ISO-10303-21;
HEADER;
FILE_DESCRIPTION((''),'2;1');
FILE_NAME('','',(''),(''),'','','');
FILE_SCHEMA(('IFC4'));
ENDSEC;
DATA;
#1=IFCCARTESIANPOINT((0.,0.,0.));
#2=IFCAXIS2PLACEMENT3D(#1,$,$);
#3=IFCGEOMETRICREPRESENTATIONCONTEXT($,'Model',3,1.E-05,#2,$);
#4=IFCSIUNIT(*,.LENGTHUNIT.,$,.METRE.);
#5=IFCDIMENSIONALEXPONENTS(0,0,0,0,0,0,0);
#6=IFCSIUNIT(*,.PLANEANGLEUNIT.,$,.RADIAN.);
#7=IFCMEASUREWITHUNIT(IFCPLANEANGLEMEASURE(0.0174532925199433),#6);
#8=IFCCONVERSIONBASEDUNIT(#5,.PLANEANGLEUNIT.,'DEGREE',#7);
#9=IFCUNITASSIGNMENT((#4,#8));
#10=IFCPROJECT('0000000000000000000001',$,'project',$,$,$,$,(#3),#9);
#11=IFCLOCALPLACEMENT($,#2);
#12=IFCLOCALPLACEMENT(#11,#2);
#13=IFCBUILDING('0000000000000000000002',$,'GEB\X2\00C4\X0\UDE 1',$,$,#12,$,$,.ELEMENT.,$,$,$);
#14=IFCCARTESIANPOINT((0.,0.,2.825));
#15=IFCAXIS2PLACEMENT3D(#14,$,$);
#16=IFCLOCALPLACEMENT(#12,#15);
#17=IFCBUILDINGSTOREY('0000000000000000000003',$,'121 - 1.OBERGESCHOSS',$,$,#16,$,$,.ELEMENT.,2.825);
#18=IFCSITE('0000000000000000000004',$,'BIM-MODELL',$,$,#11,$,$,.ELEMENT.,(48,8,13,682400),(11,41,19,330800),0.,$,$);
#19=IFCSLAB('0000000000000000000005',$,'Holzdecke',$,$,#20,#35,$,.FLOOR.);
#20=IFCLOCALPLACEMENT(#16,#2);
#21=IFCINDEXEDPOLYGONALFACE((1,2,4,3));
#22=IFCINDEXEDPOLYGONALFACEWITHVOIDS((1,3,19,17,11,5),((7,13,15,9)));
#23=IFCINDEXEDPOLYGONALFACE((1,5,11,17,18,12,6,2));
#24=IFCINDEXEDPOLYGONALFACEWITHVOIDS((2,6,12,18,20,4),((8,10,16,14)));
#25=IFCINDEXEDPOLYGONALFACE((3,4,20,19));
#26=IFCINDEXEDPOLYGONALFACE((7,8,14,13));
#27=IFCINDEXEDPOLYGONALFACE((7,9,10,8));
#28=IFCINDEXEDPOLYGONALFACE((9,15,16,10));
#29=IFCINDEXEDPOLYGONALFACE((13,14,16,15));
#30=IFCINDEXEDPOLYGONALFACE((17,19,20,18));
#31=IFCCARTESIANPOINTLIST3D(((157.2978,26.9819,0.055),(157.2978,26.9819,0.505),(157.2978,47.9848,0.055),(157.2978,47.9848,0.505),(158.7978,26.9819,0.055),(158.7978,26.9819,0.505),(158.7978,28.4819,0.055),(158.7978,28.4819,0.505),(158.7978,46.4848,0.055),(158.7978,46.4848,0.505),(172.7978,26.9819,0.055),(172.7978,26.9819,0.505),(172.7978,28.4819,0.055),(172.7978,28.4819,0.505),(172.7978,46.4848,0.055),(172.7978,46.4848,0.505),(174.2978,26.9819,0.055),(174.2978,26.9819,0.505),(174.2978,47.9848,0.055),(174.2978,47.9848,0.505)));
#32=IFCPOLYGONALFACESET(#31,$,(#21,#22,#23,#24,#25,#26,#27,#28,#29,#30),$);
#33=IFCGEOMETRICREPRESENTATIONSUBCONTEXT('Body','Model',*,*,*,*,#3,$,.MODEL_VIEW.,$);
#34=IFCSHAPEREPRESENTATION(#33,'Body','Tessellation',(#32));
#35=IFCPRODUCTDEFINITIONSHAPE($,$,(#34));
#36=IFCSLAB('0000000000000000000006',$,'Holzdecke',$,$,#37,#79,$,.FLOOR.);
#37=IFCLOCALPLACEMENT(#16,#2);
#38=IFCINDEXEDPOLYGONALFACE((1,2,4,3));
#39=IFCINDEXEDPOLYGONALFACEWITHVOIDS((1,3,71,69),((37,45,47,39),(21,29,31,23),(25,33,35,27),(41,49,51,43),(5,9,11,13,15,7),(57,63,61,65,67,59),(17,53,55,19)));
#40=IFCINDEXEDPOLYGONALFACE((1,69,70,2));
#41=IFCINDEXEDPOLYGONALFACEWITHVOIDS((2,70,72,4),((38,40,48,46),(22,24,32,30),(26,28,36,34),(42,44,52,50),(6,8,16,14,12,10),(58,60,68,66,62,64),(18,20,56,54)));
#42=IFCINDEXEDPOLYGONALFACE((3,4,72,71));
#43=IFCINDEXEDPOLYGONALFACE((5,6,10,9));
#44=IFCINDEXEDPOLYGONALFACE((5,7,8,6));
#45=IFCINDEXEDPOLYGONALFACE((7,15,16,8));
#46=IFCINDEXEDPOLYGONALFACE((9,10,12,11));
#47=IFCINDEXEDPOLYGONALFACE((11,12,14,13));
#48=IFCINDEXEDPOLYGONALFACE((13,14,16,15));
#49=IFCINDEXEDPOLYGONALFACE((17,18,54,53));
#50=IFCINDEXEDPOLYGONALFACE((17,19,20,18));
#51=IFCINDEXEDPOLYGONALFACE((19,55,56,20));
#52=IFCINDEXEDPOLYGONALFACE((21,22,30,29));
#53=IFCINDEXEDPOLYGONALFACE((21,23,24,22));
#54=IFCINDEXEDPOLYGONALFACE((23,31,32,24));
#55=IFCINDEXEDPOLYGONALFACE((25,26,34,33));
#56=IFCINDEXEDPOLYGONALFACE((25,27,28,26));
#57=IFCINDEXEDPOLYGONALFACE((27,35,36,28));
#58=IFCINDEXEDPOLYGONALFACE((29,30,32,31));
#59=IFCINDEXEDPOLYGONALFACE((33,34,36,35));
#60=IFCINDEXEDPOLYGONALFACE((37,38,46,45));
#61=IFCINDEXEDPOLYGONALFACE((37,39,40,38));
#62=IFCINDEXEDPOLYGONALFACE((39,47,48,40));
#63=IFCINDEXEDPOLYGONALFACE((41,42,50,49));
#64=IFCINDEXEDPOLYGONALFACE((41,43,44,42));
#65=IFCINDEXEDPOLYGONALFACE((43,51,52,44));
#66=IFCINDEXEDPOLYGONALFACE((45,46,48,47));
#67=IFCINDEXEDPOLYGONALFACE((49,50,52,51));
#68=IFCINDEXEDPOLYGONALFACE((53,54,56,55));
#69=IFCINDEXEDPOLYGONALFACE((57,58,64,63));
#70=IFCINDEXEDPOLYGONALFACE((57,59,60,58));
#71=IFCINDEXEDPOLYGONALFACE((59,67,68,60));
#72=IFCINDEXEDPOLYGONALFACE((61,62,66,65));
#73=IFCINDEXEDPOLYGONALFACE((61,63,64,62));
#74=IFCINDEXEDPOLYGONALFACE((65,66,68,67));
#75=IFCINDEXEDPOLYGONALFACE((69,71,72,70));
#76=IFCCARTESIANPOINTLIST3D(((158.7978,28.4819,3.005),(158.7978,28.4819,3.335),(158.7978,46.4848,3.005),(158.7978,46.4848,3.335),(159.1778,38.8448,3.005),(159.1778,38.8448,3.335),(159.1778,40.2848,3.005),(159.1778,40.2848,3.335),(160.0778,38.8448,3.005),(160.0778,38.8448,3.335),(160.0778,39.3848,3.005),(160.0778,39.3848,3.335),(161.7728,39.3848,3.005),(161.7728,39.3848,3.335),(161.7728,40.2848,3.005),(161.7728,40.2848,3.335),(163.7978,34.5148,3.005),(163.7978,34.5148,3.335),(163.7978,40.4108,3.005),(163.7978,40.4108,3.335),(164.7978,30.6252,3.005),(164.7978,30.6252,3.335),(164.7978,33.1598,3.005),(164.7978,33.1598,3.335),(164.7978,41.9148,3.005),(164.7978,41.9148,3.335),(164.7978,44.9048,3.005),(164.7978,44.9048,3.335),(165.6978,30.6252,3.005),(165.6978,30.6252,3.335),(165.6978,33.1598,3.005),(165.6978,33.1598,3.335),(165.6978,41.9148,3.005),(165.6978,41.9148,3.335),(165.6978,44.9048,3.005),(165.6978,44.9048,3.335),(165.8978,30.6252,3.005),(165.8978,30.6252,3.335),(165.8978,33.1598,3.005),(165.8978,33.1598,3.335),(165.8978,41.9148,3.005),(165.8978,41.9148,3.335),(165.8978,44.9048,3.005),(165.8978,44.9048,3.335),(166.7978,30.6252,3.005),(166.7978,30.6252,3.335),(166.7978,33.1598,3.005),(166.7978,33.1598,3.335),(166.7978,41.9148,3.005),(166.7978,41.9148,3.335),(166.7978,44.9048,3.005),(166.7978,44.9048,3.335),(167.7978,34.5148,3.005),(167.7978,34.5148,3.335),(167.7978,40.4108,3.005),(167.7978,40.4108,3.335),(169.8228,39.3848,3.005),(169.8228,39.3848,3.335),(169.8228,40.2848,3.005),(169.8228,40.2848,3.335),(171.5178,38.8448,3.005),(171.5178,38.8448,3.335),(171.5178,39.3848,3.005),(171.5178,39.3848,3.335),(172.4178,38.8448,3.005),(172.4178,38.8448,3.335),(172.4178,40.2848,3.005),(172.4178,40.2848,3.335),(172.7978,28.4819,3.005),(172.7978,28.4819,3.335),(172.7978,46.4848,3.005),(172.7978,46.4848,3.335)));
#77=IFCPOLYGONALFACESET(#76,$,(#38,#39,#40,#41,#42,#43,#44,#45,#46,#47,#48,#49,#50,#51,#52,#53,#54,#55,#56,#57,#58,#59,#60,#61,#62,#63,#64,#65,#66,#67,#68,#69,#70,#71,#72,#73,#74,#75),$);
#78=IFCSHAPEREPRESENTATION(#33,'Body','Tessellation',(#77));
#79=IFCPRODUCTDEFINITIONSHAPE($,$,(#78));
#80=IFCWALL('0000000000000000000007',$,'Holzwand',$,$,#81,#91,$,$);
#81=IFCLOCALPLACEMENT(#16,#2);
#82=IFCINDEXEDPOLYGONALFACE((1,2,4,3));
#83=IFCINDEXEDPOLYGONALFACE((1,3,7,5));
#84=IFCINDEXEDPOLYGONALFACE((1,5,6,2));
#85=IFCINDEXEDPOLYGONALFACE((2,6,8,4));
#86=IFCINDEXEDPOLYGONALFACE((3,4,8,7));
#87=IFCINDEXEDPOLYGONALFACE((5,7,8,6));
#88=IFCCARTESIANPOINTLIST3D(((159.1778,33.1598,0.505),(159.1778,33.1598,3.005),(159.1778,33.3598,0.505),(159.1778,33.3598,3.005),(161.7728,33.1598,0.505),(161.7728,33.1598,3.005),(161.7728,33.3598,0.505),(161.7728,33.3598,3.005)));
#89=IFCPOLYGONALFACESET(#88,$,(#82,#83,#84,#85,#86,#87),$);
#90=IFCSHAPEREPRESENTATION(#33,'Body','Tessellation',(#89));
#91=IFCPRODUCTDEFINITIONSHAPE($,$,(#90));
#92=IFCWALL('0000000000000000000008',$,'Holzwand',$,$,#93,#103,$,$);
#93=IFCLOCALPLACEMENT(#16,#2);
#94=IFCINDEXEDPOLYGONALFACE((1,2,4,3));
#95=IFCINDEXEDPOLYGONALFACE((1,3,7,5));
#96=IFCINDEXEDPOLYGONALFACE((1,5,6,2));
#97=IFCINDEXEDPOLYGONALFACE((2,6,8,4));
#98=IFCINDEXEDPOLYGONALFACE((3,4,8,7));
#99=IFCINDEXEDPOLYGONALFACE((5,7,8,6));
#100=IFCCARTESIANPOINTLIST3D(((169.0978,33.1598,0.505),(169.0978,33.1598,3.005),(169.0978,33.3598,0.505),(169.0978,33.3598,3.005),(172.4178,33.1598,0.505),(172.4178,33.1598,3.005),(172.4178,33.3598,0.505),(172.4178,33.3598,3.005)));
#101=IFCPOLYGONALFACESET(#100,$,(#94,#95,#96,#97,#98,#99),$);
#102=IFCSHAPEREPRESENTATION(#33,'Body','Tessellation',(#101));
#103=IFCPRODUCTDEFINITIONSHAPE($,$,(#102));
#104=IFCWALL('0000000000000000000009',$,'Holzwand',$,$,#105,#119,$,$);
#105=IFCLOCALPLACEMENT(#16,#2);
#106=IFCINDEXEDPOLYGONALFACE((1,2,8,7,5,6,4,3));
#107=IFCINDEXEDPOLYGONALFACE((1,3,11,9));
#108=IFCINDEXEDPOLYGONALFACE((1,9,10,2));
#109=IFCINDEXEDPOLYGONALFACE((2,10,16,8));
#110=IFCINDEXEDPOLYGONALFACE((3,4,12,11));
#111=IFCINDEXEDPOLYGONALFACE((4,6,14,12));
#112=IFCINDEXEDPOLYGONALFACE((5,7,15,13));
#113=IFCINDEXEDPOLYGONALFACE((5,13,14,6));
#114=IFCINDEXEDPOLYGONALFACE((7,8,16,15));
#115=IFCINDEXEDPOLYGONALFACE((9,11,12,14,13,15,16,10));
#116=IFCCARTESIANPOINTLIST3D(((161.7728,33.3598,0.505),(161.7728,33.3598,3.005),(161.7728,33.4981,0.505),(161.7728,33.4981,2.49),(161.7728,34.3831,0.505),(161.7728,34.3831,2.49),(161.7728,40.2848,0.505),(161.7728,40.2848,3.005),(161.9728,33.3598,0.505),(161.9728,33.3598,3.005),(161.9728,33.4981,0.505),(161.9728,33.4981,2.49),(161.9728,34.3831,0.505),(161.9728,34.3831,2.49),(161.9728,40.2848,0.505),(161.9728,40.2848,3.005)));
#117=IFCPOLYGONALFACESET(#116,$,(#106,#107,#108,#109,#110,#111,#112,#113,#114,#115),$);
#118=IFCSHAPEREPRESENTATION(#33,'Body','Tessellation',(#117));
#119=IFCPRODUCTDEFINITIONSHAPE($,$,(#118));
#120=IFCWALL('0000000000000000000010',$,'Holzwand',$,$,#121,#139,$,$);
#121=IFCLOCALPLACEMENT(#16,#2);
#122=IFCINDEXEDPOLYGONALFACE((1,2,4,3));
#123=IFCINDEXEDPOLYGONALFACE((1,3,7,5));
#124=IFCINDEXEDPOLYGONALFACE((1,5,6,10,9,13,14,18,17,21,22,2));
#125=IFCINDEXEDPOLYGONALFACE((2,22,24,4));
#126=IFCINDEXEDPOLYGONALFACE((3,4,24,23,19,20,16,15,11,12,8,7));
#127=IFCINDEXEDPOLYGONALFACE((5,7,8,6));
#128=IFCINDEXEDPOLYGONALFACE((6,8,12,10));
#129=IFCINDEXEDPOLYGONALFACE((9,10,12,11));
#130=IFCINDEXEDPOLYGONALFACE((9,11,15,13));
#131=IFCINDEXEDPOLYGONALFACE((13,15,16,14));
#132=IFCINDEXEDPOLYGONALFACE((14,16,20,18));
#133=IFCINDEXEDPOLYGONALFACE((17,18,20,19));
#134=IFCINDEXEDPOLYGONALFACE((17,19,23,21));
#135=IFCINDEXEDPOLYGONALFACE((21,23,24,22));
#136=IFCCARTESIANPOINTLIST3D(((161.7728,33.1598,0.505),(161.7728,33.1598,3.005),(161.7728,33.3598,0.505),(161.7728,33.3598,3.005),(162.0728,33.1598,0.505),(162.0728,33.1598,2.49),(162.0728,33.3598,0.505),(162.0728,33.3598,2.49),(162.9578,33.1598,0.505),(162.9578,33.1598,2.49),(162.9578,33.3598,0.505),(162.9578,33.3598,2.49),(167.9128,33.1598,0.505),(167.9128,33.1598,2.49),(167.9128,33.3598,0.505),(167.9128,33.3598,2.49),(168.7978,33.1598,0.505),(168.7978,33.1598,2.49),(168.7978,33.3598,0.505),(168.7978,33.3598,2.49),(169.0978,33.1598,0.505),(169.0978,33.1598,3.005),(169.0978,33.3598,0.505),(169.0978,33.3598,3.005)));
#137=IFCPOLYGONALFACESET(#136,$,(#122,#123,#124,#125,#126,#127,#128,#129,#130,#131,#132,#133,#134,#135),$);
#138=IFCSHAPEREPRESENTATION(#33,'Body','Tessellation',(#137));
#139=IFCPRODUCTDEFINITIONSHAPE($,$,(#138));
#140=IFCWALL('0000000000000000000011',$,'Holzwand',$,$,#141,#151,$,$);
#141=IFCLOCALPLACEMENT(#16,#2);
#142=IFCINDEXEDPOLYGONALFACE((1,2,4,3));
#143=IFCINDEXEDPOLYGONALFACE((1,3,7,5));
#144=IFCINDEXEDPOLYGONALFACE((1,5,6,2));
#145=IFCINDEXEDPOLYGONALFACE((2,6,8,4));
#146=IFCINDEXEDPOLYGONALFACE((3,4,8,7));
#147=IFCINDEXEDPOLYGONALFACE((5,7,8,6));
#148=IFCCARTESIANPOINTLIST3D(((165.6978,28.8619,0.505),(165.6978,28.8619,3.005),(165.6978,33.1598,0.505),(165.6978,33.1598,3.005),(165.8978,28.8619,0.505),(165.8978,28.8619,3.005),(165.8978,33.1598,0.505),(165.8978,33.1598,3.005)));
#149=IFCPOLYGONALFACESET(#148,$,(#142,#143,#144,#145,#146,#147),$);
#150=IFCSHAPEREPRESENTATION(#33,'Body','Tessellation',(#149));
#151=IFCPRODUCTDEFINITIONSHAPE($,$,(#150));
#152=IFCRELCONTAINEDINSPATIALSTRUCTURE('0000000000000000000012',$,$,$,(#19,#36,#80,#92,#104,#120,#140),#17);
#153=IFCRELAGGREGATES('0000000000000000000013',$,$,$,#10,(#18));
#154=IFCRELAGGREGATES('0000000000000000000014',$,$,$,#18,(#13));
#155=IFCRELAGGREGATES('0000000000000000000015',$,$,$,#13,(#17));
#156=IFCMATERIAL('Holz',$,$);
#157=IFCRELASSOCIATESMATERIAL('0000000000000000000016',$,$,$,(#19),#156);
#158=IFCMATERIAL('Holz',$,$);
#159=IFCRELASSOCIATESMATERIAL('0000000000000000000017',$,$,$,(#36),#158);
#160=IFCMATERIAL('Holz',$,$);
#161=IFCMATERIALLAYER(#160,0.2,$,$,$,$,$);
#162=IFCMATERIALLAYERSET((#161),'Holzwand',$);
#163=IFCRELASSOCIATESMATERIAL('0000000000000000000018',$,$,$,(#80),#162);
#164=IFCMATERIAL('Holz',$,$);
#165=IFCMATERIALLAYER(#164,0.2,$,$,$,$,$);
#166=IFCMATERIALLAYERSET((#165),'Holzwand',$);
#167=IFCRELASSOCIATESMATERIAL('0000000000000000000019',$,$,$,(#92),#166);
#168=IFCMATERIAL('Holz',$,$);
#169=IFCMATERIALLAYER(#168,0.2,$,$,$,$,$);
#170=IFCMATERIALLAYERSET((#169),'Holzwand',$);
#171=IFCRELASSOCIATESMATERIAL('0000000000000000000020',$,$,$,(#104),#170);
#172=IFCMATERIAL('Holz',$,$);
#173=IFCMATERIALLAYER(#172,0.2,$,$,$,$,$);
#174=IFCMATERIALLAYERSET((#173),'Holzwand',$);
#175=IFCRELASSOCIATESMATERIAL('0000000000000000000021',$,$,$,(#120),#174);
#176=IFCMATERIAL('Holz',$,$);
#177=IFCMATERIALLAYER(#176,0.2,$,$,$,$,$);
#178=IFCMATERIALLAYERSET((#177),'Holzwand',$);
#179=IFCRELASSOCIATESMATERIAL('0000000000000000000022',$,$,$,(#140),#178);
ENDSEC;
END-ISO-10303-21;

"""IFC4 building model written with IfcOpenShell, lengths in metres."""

from ifc_helpers import new_model, entity, si_unit, converted_unit, frame, frame_2d, origin, origin_with_axes, place, context, subcontext, project, spatial, polyline, rectangle, outline, extrude, material, layer, layer_set, layer_usage, element, save


model = new_model("IFC4")

# Units and contexts
model_context = context("Model", 3, precision=1e-05, world=origin())
body_context = subcontext(model_context, "Body", "Model", "MODEL_VIEW")
ifc_project = project(units=[si_unit("LENGTHUNIT", "METRE"), converted_unit("PLANEANGLEUNIT", "DEGREE", entity("IfcPlaneAngleMeasure", 0.0174532925199433), si_unit("PLANEANGLEUNIT", "RADIAN"), dimensions=[0, 0, 0, 0, 0, 0, 0])], contexts=[model_context])

# Site, building, storey
site_placement = place(None, origin())
site = spatial("IfcSite", under=ifc_project, at=site_placement, Name="BIM-MODELL", CompositionType="ELEMENT", RefLatitude=(48, 8, 13, 682400), RefLongitude=(11, 41, 19, 330800), RefElevation=0.0)
building_placement = place(site_placement, origin())
building = spatial("IfcBuilding", under=site, at=building_placement, Name="GEBÄUDE 1", CompositionType="ELEMENT")
storey_placement = place(building_placement, frame((0.0, 0.0, 2.825)))
storey = spatial("IfcBuildingStorey", under=building, at=storey_placement, Name="121 - 1.OBERGESCHOSS", CompositionType="ELEMENT", Elevation=2.825)

# Slab
ifc_material_1 = material(Name="Holz")
slab_1_placement = place(storey_placement, frame((157.2978, 26.9819, 0.055)))
element("IfcSlab", 1, at=slab_1_placement, inside=storey, material=ifc_material_1, Name="Holzdecke", PredefinedType="FLOOR", context=body_context, shape_type="SweptSolid", body=[
    extrude(outline(polyline([(17.0, 0.0), (17.0, 21.0029), (0.0, 21.0029), (0.0, 0.0), (1.5, 0.0), (15.5, 0.0), (17.0, 0.0)]), holes=[polyline([(15.5, 19.5029), (15.5, 1.5), (1.5, 1.5), (1.5, 19.5029), (15.5, 19.5029)])]), origin_with_axes(), (0.0, 0.0, 1.0), 0.45),
])

# Slab, opening
ifc_material_2 = material(Name="Holz")
slab_2_placement = place(storey_placement, frame((158.7978, 28.4819, 3.005)))
slab_2 = element("IfcSlab", 2, at=slab_2_placement, inside=storey, material=ifc_material_2, Name="Holzdecke", PredefinedType="FLOOR", context=body_context, shape_type="SweptSolid", body=[
    extrude(outline(polyline([(0.0, 0.0), (14.0, 0.0), (14.0, 18.0029), (0.0, 18.0029), (0.0, 0.0)]), holes=[polyline([(9.0, 6.0329), (5.0, 6.0329), (5.0, 11.9289), (9.0, 11.9289), (9.0, 6.0329)]), polyline([(13.62, 10.3629), (12.72, 10.3629), (12.72, 10.9029), (11.025, 10.9029), (11.025, 11.8029), (13.62, 11.8029), (13.62, 10.3629)]), polyline([(8.0, 16.4229), (8.0, 13.4329), (7.1, 13.4329), (7.1, 16.4229), (8.0, 16.4229)]), polyline([(6.0, 16.4229), (6.9, 16.4229), (6.9, 13.4329), (6.0, 13.4329), (6.0, 16.4229)]), polyline([(6.9, 2.1433), (6.0, 2.1433), (6.0, 4.6779), (6.9, 4.6779), (6.9, 2.1433)]), polyline([(8.0, 2.1433), (7.1, 2.1433), (7.1, 4.6779), (8.0, 4.6779), (8.0, 2.1433)])]), origin_with_axes(), (0.0, 0.0, 1.0), 0.33),
])
opening_1_placement = place(slab_2_placement, frame((0.38, 10.3629, 0.0)))
element("IfcOpeningElement", 3, at=opening_1_placement, cuts=slab_2, ObjectType="Opening", context=body_context, shape_type="SweptSolid", body=[
    extrude(outline(polyline([(1.43, 0.78), (-1.165, 0.78), (-1.165, -0.66), (-0.265, -0.66), (-0.265, -0.12), (1.43, -0.12), (1.43, 0.78)])), frame((1.165, 0.66, 0.0), z_axis=(0.0, 0.0, 1.0), x_axis=(1.0, 0.0, 0.0)), (0.0, 0.0, 1.0), 0.33),
])

# Walls
ifc_material_3 = material(Name="Holz")
ifc_layer_1 = layer(ifc_material_3, 0.2)
ifc_layer_set_1 = layer_set([ifc_layer_1], Name="Holzwand")
ifc_layer_usage_1 = layer_usage(ifc_layer_set_1, "AXIS2", "POSITIVE", 0.0)
wall_1_placement = place(storey_placement, frame((159.1778, 33.1598, 0.505)))
element("IfcWall", 4, at=wall_1_placement, inside=storey, material=ifc_layer_usage_1, Name="Holzwand", context=body_context, shape_type="SweptSolid", body=[
    extrude(rectangle(XDim=2.595, YDim=0.2, at=frame_2d((1.2975, 0.1), x_axis=(1.0, 0.0))), origin_with_axes(), (0.0, 0.0, 1.0), 2.5),
])
ifc_material_4 = material(Name="Holz")
ifc_layer_2 = layer(ifc_material_4, 0.2)
ifc_layer_set_2 = layer_set([ifc_layer_2], Name="Holzwand")
ifc_layer_usage_2 = layer_usage(ifc_layer_set_2, "AXIS2", "POSITIVE", 0.0)
wall_2_placement = place(storey_placement, frame((169.0978, 33.1598, 0.505)))
element("IfcWall", 5, at=wall_2_placement, inside=storey, material=ifc_layer_usage_2, Name="Holzwand", context=body_context, shape_type="SweptSolid", body=[
    extrude(rectangle(XDim=3.32, YDim=0.2, at=frame_2d((1.66, 0.1), x_axis=(1.0, 0.0))), origin_with_axes(), (0.0, 0.0, 1.0), 2.5),
])

# Wall, opening
ifc_material_5 = material(Name="Holz")
ifc_layer_3 = layer(ifc_material_5, 0.2)
ifc_layer_set_3 = layer_set([ifc_layer_3], Name="Holzwand")
ifc_layer_usage_3 = layer_usage(ifc_layer_set_3, "AXIS2", "POSITIVE", 0.0)
wall_3_placement = place(storey_placement, frame((161.9728, 33.3598, 0.505), z_axis=(0.0, 0.0, 1.0), x_axis=(0.0, 1.0, 0.0)))
wall_3 = element("IfcWall", 6, at=wall_3_placement, inside=storey, material=ifc_layer_usage_3, Name="Holzwand", context=body_context, shape_type="SweptSolid", body=[
    extrude(rectangle(XDim=6.925, YDim=0.2, at=frame_2d((3.4625, 0.1), x_axis=(1.0, 0.0))), origin_with_axes(), (0.0, 0.0, 1.0), 2.5),
])
opening_2_placement = place(wall_3_placement, frame((0.1383, 0.0, -0.15), z_axis=(0.0, 1.0, 0.0), x_axis=(0.0, 0.0, 1.0)))
element("IfcOpeningElement", 7, at=opening_2_placement, cuts=wall_3, ObjectType="Opening", context=body_context, shape_type="SweptSolid", body=[
    extrude(outline(polyline([(0.0, 0.885), (2.135, 0.885), (2.135, 0.0), (0.0, 0.0), (0.0, 0.885)])), origin_with_axes(), (0.0, 0.0, 1.0), 0.2),
])

# Wall, openings
ifc_material_6 = material(Name="Holz")
ifc_layer_4 = layer(ifc_material_6, 0.2)
ifc_layer_set_4 = layer_set([ifc_layer_4], Name="Holzwand")
ifc_layer_usage_4 = layer_usage(ifc_layer_set_4, "AXIS2", "POSITIVE", 0.0)
wall_4_placement = place(storey_placement, frame((169.0978, 33.3598, 0.505), z_axis=(0.0, 0.0, 1.0), x_axis=(-1.0, 0.0, 0.0)))
wall_4 = element("IfcWall", 8, at=wall_4_placement, inside=storey, material=ifc_layer_usage_4, Name="Holzwand", context=body_context, shape_type="SweptSolid", body=[
    extrude(rectangle(XDim=7.325, YDim=0.2, at=frame_2d((3.6625, 0.1), x_axis=(1.0, 0.0))), origin_with_axes(), (0.0, 0.0, 1.0), 2.5),
])
opening_3_placement = place(wall_4_placement, frame((0.3, 0.0, -0.15), z_axis=(0.0, 1.0, 0.0), x_axis=(0.0, 0.0, 1.0)))
element("IfcOpeningElement", 9, at=opening_3_placement, cuts=wall_4, ObjectType="Opening", context=body_context, shape_type="SweptSolid", body=[
    extrude(outline(polyline([(0.0, 0.885), (2.135, 0.885), (2.135, 0.0), (0.0, 0.0), (0.0, 0.885)])), origin_with_axes(), (0.0, 0.0, 1.0), 0.2),
])
opening_4_placement = place(wall_4_placement, frame((6.14, 0.0, -0.15), z_axis=(0.0, 1.0, 0.0), x_axis=(0.0, 0.0, 1.0)))
element("IfcOpeningElement", 10, at=opening_4_placement, cuts=wall_4, ObjectType="Opening", context=body_context, shape_type="SweptSolid", body=[
    extrude(outline(polyline([(0.0, 0.885), (2.135, 0.885), (2.135, 0.0), (0.0, 0.0), (0.0, 0.885)])), origin_with_axes(), (0.0, 0.0, 1.0), 0.2),
])

# Wall
ifc_material_7 = material(Name="Holz")
ifc_layer_5 = layer(ifc_material_7, 0.2)
ifc_layer_set_5 = layer_set([ifc_layer_5], Name="Holzwand")
ifc_layer_usage_5 = layer_usage(ifc_layer_set_5, "AXIS2", "POSITIVE", 0.0)
wall_5_placement = place(storey_placement, frame((165.6978, 33.1598, 0.505), z_axis=(0.0, 0.0, 1.0), x_axis=(0.0, -1.0, 0.0)))
element("IfcWall", 11, at=wall_5_placement, inside=storey, material=ifc_layer_usage_5, Name="Holzwand", context=body_context, shape_type="SweptSolid", body=[
    extrude(rectangle(XDim=4.2979, YDim=0.2, at=frame_2d((2.1489, 0.1), x_axis=(1.0, 0.0))), origin_with_axes(), (0.0, 0.0, 1.0), 2.5),
])

save(model, "model.ifc")
